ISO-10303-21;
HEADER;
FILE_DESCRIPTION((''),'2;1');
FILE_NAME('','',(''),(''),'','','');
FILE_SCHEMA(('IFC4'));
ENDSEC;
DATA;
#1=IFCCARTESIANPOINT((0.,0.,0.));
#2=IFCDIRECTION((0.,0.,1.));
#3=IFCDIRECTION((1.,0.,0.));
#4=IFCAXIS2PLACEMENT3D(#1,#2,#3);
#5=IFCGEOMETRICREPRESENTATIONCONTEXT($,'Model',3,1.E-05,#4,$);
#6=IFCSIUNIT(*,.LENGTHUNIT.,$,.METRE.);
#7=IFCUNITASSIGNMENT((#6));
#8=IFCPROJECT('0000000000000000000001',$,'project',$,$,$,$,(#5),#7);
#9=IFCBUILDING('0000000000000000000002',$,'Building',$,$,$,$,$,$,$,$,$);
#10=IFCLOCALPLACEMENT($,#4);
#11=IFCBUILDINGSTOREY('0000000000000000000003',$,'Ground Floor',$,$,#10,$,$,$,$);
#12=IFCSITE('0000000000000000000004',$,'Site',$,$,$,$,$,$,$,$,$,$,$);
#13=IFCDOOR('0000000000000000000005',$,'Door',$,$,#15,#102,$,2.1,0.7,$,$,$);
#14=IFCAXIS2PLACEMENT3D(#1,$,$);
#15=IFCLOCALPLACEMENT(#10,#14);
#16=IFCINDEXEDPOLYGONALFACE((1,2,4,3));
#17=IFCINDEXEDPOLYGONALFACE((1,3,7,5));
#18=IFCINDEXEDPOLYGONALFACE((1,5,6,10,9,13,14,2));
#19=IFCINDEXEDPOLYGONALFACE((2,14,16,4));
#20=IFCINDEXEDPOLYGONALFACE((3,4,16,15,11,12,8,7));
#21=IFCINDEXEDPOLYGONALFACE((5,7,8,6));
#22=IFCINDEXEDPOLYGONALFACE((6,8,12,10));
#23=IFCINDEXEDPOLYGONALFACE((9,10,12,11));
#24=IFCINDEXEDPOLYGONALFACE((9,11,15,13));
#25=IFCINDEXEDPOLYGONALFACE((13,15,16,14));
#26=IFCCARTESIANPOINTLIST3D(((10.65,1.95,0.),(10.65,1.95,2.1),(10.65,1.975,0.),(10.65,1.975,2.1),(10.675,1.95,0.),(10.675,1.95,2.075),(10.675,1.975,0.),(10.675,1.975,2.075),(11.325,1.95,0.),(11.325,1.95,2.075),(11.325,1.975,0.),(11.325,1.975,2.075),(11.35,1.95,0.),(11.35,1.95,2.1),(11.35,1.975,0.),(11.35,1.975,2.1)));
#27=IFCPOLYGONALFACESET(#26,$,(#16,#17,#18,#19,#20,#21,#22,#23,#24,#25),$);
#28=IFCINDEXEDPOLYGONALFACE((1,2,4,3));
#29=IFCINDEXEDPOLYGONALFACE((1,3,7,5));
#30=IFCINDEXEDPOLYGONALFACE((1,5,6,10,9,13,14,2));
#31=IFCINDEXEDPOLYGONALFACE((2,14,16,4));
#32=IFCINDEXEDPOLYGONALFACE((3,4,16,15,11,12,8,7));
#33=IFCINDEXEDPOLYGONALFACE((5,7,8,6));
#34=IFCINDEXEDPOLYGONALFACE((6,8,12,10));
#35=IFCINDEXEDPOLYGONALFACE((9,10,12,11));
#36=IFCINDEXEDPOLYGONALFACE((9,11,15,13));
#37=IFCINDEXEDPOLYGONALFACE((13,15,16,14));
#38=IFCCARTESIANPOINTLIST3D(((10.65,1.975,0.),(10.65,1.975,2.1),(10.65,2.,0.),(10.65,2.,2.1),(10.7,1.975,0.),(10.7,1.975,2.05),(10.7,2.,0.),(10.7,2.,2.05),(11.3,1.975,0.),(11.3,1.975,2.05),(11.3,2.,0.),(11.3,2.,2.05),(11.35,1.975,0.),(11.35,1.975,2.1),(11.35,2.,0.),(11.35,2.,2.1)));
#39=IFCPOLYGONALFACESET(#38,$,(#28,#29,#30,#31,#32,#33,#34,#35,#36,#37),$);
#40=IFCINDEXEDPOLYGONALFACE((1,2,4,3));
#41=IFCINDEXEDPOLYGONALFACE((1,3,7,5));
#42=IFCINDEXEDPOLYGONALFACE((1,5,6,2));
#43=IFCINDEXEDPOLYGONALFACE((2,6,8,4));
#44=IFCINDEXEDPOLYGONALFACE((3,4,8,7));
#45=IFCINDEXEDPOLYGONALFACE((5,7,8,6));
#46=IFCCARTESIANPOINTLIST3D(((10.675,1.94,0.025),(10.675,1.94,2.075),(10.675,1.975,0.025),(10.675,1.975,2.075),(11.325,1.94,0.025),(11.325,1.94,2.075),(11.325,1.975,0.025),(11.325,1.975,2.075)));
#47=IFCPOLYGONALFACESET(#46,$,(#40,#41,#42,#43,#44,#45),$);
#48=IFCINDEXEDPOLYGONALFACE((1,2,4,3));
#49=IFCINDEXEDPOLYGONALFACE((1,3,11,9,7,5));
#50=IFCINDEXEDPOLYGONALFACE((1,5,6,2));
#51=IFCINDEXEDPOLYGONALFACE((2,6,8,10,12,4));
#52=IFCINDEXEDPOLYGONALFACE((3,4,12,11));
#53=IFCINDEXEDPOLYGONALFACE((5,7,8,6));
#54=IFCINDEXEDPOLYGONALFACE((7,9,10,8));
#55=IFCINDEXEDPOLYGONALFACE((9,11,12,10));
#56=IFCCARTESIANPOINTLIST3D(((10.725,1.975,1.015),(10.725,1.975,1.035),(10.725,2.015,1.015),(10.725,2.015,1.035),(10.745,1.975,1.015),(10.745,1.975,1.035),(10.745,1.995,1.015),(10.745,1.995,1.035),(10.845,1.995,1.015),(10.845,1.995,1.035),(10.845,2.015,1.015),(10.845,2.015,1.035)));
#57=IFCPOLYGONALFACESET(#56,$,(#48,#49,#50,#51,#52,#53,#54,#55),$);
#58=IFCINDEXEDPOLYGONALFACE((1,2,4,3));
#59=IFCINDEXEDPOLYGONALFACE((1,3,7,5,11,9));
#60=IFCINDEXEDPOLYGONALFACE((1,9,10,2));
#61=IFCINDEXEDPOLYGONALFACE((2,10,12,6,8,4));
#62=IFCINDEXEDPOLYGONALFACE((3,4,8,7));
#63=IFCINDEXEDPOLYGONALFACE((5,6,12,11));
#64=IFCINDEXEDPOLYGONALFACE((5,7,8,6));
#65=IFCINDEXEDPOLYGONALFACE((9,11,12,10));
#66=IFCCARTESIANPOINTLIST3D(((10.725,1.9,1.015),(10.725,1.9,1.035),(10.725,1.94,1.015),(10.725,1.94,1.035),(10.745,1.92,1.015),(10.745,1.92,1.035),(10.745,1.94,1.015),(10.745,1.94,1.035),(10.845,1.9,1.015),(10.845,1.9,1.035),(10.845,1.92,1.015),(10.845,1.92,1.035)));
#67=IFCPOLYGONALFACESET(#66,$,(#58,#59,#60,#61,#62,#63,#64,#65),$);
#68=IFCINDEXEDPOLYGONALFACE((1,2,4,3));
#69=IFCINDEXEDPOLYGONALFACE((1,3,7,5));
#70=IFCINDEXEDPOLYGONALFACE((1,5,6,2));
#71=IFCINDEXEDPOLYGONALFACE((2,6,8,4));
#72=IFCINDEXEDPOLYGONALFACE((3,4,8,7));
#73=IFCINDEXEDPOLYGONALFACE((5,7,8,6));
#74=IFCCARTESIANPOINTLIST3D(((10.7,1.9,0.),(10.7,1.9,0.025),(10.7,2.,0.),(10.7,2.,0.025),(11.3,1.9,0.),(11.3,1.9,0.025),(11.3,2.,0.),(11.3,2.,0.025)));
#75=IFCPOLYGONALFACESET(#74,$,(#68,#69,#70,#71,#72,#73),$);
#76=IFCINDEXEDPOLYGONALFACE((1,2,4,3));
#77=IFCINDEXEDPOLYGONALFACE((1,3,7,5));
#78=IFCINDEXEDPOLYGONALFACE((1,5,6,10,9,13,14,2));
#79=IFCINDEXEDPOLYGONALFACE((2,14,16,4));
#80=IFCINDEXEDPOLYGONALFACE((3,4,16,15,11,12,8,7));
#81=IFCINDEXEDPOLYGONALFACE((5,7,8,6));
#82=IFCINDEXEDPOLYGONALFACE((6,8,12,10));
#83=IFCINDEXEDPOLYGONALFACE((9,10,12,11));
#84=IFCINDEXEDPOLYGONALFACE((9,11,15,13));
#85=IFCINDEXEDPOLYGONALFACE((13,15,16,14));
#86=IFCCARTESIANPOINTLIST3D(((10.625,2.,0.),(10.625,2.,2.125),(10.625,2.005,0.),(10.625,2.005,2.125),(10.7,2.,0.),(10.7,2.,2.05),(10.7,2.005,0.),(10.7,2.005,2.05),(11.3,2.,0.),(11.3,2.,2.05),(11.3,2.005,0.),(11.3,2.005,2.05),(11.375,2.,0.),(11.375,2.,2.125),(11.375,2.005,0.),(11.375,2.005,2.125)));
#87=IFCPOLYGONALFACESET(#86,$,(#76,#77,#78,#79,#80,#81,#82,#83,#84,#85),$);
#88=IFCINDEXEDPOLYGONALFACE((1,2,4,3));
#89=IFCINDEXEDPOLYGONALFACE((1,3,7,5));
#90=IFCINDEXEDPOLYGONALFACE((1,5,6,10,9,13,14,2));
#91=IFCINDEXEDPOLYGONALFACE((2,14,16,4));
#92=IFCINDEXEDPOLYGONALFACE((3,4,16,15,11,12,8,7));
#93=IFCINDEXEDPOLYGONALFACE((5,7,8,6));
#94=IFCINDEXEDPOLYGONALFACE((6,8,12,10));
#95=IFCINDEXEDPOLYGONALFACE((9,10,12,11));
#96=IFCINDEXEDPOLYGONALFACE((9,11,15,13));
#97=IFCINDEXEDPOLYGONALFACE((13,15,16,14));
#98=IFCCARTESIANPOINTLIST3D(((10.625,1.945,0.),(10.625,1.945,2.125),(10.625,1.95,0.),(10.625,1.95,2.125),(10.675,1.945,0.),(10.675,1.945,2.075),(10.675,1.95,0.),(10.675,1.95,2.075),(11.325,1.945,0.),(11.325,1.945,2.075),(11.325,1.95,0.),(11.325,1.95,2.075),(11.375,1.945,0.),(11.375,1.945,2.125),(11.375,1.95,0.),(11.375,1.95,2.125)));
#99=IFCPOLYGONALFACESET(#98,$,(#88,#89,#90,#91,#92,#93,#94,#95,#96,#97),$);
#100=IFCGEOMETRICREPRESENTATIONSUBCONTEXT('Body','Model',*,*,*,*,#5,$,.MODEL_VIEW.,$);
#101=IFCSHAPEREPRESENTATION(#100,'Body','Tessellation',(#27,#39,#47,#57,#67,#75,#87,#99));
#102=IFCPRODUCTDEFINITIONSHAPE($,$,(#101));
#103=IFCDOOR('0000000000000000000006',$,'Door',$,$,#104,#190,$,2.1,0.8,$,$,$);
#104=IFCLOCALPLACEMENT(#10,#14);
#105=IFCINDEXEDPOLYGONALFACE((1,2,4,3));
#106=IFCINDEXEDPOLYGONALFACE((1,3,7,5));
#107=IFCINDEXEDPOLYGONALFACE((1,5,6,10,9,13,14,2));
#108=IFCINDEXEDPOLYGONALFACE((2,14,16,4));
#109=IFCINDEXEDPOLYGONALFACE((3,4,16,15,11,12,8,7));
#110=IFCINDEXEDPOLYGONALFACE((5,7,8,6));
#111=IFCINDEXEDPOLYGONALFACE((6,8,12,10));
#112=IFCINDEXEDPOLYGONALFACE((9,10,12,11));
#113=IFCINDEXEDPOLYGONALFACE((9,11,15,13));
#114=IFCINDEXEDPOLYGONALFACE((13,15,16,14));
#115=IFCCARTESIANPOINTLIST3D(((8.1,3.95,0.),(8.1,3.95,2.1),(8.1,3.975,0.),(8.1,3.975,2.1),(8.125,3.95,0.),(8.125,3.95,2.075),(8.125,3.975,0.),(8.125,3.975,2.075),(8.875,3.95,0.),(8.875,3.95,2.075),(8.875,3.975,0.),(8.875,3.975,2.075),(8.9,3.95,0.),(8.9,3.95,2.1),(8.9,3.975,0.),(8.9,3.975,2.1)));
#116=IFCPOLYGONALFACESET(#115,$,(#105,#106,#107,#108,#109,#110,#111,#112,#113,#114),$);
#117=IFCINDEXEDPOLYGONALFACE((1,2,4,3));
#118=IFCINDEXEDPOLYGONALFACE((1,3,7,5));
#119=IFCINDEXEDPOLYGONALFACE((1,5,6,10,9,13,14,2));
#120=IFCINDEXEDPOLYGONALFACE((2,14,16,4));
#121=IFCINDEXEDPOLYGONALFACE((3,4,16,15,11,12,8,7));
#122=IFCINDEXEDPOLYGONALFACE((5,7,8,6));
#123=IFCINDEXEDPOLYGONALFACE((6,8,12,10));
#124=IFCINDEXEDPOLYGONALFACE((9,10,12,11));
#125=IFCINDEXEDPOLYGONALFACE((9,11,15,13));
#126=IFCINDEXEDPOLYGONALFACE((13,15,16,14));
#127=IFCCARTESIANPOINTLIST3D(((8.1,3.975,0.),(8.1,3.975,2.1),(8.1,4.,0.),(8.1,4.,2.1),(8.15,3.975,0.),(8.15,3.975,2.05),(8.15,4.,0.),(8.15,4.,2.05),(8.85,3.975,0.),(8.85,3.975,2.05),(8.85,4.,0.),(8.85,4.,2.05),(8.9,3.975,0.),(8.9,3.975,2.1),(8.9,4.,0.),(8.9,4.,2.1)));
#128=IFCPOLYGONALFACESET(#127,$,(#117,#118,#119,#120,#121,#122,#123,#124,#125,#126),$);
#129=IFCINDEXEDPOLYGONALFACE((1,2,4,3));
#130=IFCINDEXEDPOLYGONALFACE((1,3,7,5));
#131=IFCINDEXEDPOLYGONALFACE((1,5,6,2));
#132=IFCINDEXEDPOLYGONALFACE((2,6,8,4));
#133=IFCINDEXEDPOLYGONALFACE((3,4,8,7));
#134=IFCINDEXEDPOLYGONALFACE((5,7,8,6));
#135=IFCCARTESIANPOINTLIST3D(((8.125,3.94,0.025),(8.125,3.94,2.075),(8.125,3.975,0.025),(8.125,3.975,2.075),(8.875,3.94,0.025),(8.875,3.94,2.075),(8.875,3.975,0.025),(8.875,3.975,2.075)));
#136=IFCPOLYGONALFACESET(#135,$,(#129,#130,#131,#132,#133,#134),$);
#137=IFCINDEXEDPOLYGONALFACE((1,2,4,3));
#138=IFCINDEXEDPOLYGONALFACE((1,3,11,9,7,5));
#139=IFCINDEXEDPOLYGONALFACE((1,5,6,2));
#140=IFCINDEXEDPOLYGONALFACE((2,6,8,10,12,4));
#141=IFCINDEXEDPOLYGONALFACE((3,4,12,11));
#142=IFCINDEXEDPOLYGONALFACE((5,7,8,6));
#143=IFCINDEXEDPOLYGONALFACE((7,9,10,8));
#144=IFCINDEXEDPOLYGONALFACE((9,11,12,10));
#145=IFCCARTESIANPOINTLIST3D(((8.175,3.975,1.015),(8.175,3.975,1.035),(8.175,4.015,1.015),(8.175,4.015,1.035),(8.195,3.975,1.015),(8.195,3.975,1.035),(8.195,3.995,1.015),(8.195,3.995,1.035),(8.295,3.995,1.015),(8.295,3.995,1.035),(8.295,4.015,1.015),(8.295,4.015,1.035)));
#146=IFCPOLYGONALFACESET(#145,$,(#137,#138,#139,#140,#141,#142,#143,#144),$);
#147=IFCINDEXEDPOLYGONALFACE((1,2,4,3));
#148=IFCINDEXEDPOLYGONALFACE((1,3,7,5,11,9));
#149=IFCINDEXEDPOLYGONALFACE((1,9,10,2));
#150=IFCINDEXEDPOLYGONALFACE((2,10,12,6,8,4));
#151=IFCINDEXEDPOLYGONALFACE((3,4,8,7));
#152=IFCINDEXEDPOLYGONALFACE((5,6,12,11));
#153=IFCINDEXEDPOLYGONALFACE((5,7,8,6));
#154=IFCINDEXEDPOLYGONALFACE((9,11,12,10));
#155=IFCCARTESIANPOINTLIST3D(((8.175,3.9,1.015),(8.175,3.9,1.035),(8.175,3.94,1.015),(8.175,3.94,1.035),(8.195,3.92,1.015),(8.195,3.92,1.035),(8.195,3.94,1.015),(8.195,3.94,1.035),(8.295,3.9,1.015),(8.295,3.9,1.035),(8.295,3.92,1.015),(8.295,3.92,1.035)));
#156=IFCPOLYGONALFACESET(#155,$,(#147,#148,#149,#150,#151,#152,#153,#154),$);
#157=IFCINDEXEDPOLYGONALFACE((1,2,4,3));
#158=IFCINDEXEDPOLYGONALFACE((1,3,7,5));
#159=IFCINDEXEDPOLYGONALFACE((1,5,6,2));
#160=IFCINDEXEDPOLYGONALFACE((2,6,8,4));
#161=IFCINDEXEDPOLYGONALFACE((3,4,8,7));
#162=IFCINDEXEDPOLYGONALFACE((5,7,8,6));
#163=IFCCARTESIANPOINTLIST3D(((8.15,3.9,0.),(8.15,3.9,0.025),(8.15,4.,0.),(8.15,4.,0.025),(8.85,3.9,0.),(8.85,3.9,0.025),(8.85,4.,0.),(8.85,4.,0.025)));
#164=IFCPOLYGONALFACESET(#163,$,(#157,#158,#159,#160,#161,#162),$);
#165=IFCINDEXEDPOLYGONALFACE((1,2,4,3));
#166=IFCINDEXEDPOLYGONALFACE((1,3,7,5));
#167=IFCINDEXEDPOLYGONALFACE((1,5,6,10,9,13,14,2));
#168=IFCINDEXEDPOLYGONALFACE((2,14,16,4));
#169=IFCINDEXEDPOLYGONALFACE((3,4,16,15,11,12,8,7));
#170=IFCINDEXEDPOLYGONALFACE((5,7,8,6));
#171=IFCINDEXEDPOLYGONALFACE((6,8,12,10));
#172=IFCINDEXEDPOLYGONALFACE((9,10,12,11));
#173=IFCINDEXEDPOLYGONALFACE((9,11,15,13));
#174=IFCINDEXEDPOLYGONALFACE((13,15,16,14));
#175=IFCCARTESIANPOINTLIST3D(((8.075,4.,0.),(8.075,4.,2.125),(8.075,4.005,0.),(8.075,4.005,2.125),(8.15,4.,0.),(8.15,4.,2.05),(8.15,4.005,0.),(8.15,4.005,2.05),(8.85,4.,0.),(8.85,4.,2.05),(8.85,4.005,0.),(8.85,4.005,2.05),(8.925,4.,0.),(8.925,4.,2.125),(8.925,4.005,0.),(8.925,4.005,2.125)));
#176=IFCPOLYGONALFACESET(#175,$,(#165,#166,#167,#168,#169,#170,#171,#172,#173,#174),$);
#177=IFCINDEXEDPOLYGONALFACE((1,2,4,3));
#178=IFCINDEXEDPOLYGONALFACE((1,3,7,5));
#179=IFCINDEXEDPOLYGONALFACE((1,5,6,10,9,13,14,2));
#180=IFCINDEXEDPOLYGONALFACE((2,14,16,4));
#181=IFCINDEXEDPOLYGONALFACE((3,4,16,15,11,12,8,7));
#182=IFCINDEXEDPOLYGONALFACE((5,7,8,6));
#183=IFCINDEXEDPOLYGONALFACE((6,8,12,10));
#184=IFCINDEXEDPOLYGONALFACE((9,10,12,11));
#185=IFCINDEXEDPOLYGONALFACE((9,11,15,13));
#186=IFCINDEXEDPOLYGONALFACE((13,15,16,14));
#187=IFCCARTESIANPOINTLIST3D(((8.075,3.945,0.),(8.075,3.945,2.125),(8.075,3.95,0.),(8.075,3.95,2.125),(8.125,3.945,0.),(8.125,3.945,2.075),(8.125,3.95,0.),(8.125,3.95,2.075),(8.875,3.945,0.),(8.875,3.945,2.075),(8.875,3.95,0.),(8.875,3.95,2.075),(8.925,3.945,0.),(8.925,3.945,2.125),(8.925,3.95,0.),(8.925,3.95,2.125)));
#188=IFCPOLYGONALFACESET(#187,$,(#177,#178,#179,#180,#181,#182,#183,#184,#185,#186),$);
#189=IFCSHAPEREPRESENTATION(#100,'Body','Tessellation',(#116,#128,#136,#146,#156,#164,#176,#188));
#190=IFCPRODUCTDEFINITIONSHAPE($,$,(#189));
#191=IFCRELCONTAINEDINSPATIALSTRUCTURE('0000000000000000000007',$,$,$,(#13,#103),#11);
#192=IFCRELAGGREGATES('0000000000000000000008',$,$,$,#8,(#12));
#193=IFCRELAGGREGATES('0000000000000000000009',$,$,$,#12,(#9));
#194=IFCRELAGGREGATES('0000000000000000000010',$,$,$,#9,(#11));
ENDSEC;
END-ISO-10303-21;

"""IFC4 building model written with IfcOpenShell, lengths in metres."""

from ifc_helpers import new_model, si_unit, frame, origin_with_axes, place, context, subcontext, project, spatial, line, indexed_curve, outline, extrude, element, save


model = new_model("IFC4")

# Units and contexts
model_context = context("Model", 3, precision=1e-05, world=origin_with_axes())
body_context = subcontext(model_context, "Body", "Model", "MODEL_VIEW")
ifc_project = project(units=[si_unit("LENGTHUNIT", "METRE")], contexts=[model_context])

# Site, building, storey
site = spatial("IfcSite", under=ifc_project, Name="Site")
building = spatial("IfcBuilding", under=site, Name="Building")
storey_placement = place(None, origin_with_axes())
storey = spatial("IfcBuildingStorey", under=building, at=storey_placement, Name="Ground Floor")

# Doors
door_1_placement = place(storey_placement, frame((11.35, 2.0, 0.0), z_axis=(0.0, 0.0, 1.0), x_axis=(-1.0, 0.0, 0.0)))
element("IfcDoor", 1, at=door_1_placement, inside=storey, Name="Door", OverallHeight=2.1, OverallWidth=0.7, context=body_context, shape_type="SweptSolid", body=[
    extrude(outline(indexed_curve([(0.0, 0.0), (0.0, 2.1), (0.7, 2.1), (0.7, 0.0), (0.675, 0.0), (0.675, 2.075), (0.025, 2.075), (0.025, 0.0)], segments=[line(1, 2, 3, 4, 5, 6, 7, 8, 1)])), frame((0.0, 0.025, 0.0), z_axis=(0.0, -1.0, 0.0), x_axis=(1.0, 0.0, 0.0)), (0.0, 0.0, -1.0), 0.025),
    extrude(outline(indexed_curve([(0.0, 0.0), (0.0, 2.1), (0.7, 2.1), (0.7, 0.0), (0.65, 0.0), (0.65, 2.05), (0.05, 2.05), (0.05, 0.0)], segments=[line(1, 2, 3, 4, 5, 6, 7, 8, 1)])), frame((0.0, 0.0, 0.0), z_axis=(0.0, -1.0, 0.0), x_axis=(1.0, 0.0, 0.0)), (0.0, 0.0, -1.0), 0.025),
    extrude(outline(indexed_curve([(0.0, 0.0), (0.65, 0.0), (0.65, 0.035), (0.0, 0.035)], segments=[line(1, 2, 3, 4, 1)])), frame((0.025, 0.025, 0.025), z_axis=(0.0, 0.0, 1.0), x_axis=(1.0, 0.0, 0.0)), (0.0, 0.0, 1.0), 2.05),
    extrude(outline(indexed_curve([(0.0, 0.0), (0.0, -0.04), (-0.12, -0.04), (-0.12, -0.02), (-0.02, -0.02), (-0.02, 0.0)], segments=[line(1, 2, 3, 4, 5, 6, 1)])), frame((0.625, 0.025, 1.015), z_axis=(0.0, 0.0, 1.0), x_axis=(1.0, 0.0, 0.0)), (0.0, 0.0, 1.0), 0.02),
    extrude(outline(indexed_curve([(0.0, 0.0), (0.0, 0.04), (-0.12, 0.04), (-0.12, 0.02), (-0.02, 0.02), (-0.02, 0.0)], segments=[line(1, 2, 3, 4, 5, 6, 1)])), frame((0.625, 0.06, 1.015), z_axis=(0.0, 0.0, 1.0), x_axis=(1.0, 0.0, 0.0)), (0.0, 0.0, 1.0), 0.02),
    extrude(outline(indexed_curve([(0.0, 0.0), (0.6, 0.0), (0.6, 0.1), (0.0, 0.1)], segments=[line(1, 2, 3, 4, 1)])), frame((0.05, 0.0, 0.0), z_axis=(0.0, 0.0, 1.0), x_axis=(1.0, 0.0, 0.0)), (0.0, 0.0, 1.0), 0.025),
    extrude(outline(indexed_curve([(0.0, 0.0), (0.0, 2.125), (0.75, 2.125), (0.75, 0.0), (0.675, 0.0), (0.675, 2.05), (0.075, 2.05), (0.075, 0.0)], segments=[line(1, 2, 3, 4, 5, 6, 7, 8, 1)])), frame((-0.025, -0.005, 0.0), z_axis=(0.0, -1.0, 0.0), x_axis=(1.0, 0.0, 0.0)), (0.0, 0.0, -1.0), 0.005),
    extrude(outline(indexed_curve([(0.0, 0.0), (0.0, 2.125), (0.75, 2.125), (0.75, 0.0), (0.7, 0.0), (0.7, 2.075), (0.05, 2.075), (0.05, 0.0)], segments=[line(1, 2, 3, 4, 5, 6, 7, 8, 1)])), frame((-0.025, 0.05, 0.0), z_axis=(0.0, -1.0, 0.0), x_axis=(1.0, 0.0, 0.0)), (0.0, 0.0, -1.0), 0.005),
])
door_2_placement = place(storey_placement, frame((8.9, 4.0, 0.0), z_axis=(0.0, 0.0, 1.0), x_axis=(-1.0, 0.0, 0.0)))
element("IfcDoor", 2, at=door_2_placement, inside=storey, Name="Door", OverallHeight=2.1, OverallWidth=0.8, context=body_context, shape_type="SweptSolid", body=[
    extrude(outline(indexed_curve([(0.0, 0.0), (0.0, 2.1), (0.8, 2.1), (0.8, 0.0), (0.775, 0.0), (0.775, 2.075), (0.025, 2.075), (0.025, 0.0)], segments=[line(1, 2, 3, 4, 5, 6, 7, 8, 1)])), frame((0.0, 0.025, 0.0), z_axis=(0.0, -1.0, 0.0), x_axis=(1.0, 0.0, 0.0)), (0.0, 0.0, -1.0), 0.025),
    extrude(outline(indexed_curve([(0.0, 0.0), (0.0, 2.1), (0.8, 2.1), (0.8, 0.0), (0.75, 0.0), (0.75, 2.05), (0.05, 2.05), (0.05, 0.0)], segments=[line(1, 2, 3, 4, 5, 6, 7, 8, 1)])), frame((0.0, 0.0, 0.0), z_axis=(0.0, -1.0, 0.0), x_axis=(1.0, 0.0, 0.0)), (0.0, 0.0, -1.0), 0.025),
    extrude(outline(indexed_curve([(0.0, 0.0), (0.75, 0.0), (0.75, 0.035), (0.0, 0.035)], segments=[line(1, 2, 3, 4, 1)])), frame((0.025, 0.025, 0.025), z_axis=(0.0, 0.0, 1.0), x_axis=(1.0, 0.0, 0.0)), (0.0, 0.0, 1.0), 2.05),
    extrude(outline(indexed_curve([(0.0, 0.0), (0.0, -0.04), (-0.12, -0.04), (-0.12, -0.02), (-0.02, -0.02), (-0.02, 0.0)], segments=[line(1, 2, 3, 4, 5, 6, 1)])), frame((0.725, 0.025, 1.015), z_axis=(0.0, 0.0, 1.0), x_axis=(1.0, 0.0, 0.0)), (0.0, 0.0, 1.0), 0.02),
    extrude(outline(indexed_curve([(0.0, 0.0), (0.0, 0.04), (-0.12, 0.04), (-0.12, 0.02), (-0.02, 0.02), (-0.02, 0.0)], segments=[line(1, 2, 3, 4, 5, 6, 1)])), frame((0.725, 0.06, 1.015), z_axis=(0.0, 0.0, 1.0), x_axis=(1.0, 0.0, 0.0)), (0.0, 0.0, 1.0), 0.02),
    extrude(outline(indexed_curve([(0.0, 0.0), (0.7, 0.0), (0.7, 0.1), (0.0, 0.1)], segments=[line(1, 2, 3, 4, 1)])), frame((0.05, 0.0, 0.0), z_axis=(0.0, 0.0, 1.0), x_axis=(1.0, 0.0, 0.0)), (0.0, 0.0, 1.0), 0.025),
    extrude(outline(indexed_curve([(0.0, 0.0), (0.0, 2.125), (0.85, 2.125), (0.85, 0.0), (0.775, 0.0), (0.775, 2.05), (0.075, 2.05), (0.075, 0.0)], segments=[line(1, 2, 3, 4, 5, 6, 7, 8, 1)])), frame((-0.025, -0.005, 0.0), z_axis=(0.0, -1.0, 0.0), x_axis=(1.0, 0.0, 0.0)), (0.0, 0.0, -1.0), 0.005),
    extrude(outline(indexed_curve([(0.0, 0.0), (0.0, 2.125), (0.85, 2.125), (0.85, 0.0), (0.8, 0.0), (0.8, 2.075), (0.05, 2.075), (0.05, 0.0)], segments=[line(1, 2, 3, 4, 5, 6, 7, 8, 1)])), frame((-0.025, 0.05, 0.0), z_axis=(0.0, -1.0, 0.0), x_axis=(1.0, 0.0, 0.0)), (0.0, 0.0, -1.0), 0.005),
])

save(model, "model.ifc")
